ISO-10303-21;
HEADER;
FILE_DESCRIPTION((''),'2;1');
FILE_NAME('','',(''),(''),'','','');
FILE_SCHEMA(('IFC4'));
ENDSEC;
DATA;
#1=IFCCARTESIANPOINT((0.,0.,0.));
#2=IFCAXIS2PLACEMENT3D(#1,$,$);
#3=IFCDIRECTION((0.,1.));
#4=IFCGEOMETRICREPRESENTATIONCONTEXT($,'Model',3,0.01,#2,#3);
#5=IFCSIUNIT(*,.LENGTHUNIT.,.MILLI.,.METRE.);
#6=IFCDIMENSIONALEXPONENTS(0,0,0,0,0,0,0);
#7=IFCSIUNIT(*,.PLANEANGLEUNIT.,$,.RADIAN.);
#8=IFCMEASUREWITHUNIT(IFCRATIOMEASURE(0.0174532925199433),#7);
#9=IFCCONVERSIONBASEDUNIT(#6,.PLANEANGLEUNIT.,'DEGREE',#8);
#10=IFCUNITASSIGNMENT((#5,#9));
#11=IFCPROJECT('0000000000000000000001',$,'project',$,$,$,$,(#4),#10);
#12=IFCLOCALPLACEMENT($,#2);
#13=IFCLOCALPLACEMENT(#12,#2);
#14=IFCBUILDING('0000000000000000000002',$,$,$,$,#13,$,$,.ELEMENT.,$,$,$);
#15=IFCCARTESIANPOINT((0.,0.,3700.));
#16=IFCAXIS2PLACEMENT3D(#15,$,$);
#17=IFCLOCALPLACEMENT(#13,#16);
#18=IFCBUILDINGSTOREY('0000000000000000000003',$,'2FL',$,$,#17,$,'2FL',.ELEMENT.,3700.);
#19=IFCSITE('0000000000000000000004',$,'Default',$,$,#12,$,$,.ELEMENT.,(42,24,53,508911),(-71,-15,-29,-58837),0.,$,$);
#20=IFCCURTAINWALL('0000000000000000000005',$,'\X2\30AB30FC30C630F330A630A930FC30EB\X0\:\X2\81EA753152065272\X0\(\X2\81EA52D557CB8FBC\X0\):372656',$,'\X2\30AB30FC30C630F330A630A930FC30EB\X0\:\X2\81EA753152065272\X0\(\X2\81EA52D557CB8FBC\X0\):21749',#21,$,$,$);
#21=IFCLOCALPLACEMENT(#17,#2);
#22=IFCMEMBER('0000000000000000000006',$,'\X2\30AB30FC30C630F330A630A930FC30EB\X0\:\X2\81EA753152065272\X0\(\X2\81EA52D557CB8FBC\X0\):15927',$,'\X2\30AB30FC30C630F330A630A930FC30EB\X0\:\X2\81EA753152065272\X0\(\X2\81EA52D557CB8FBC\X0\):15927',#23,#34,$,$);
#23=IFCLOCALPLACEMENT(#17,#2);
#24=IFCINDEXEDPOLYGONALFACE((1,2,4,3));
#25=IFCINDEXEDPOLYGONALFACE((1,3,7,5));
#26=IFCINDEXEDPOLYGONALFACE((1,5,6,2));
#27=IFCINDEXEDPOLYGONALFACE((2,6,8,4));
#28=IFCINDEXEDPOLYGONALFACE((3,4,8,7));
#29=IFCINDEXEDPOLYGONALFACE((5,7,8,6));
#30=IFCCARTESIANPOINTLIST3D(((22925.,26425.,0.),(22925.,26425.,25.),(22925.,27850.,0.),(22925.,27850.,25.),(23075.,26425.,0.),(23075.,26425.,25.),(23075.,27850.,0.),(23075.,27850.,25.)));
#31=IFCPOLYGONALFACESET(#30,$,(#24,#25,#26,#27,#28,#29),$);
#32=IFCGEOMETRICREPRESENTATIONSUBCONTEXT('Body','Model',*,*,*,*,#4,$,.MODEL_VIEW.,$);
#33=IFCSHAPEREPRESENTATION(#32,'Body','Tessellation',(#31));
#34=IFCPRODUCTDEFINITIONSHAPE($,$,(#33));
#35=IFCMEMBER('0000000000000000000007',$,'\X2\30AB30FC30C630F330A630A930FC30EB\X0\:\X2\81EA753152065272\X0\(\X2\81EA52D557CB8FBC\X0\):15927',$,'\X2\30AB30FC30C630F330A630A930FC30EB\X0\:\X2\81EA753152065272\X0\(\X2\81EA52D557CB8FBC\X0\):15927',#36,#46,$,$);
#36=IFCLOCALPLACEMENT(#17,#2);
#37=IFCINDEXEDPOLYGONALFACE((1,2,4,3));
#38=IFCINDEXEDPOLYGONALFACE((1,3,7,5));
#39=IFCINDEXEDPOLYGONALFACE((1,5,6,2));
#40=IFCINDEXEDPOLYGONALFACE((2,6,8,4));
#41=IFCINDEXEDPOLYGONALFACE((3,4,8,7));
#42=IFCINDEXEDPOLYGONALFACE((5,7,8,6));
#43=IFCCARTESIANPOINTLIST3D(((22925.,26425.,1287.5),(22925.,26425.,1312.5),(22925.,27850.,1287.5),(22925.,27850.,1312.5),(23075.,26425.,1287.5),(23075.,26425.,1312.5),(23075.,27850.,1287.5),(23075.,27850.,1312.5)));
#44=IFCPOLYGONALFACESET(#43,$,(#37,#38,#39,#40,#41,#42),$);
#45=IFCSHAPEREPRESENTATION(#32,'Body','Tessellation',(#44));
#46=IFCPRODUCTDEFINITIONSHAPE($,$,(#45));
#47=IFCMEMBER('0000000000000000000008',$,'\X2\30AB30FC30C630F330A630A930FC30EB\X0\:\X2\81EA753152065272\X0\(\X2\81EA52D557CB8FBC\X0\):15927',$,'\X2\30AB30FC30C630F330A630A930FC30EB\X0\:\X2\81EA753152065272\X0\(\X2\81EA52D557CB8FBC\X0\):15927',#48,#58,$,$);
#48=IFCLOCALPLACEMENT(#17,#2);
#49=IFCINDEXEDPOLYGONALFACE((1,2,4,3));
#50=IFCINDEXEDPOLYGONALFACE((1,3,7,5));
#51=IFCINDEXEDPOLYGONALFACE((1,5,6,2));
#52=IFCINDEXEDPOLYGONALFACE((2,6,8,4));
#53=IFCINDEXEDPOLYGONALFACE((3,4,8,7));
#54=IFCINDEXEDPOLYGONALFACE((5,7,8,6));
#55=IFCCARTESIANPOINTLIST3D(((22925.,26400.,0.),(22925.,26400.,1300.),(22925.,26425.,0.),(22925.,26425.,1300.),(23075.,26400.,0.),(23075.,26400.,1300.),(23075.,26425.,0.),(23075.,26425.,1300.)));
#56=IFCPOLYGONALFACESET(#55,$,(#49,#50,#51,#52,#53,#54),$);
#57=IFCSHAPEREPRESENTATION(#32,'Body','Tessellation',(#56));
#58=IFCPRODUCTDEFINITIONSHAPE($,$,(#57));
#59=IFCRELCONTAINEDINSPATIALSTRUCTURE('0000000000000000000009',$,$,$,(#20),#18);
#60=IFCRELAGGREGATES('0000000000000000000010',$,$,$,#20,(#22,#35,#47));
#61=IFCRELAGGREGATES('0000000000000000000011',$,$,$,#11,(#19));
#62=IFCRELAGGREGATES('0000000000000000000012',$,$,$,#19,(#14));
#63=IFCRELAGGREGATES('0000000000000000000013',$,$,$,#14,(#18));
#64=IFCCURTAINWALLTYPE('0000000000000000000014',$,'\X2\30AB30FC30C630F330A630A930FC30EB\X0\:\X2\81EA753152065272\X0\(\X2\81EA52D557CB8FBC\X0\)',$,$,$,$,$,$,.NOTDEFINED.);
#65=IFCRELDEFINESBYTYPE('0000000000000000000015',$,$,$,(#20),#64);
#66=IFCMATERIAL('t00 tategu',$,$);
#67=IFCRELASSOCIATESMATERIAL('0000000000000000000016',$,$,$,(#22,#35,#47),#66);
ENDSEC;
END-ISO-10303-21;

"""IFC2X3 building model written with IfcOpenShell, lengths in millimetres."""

from ifc_helpers import new_model, entity, si_unit, converted_unit, direction, frame, frame_2d, origin, origin_2d_with_axis, place, context, subcontext, project, spatial, rectangle, extrude, material, type_object, element, aggregate, save


model = new_model("IFC2X3")

# Units and contexts
model_context = context("Model", 3, precision=0.01, world=origin(), true_north=direction((0.0, 1.0)))
body_context = subcontext(model_context, "Body", "Model", "MODEL_VIEW")
ifc_project = project(units=[si_unit("LENGTHUNIT", "METRE", prefix="MILLI"), converted_unit("PLANEANGLEUNIT", "DEGREE", entity("IfcRatioMeasure", 0.0174532925199433), si_unit("PLANEANGLEUNIT", "RADIAN"), dimensions=[0, 0, 0, 0, 0, 0, 0])], contexts=[model_context])

# Site, building, storey
site_placement = place(None, origin())
site = spatial("IfcSite", under=ifc_project, at=site_placement, Name="Default", CompositionType="ELEMENT", RefLatitude=(42, 24, 53, 508911), RefLongitude=(-71, -15, -29, -58837), RefElevation=0.0)
building_placement = place(site_placement, origin())
building = spatial("IfcBuilding", under=site, at=building_placement, CompositionType="ELEMENT")
storey_placement = place(building_placement, frame((0.0, 0.0, 3700.0)))
storey = spatial("IfcBuildingStorey", under=building, at=storey_placement, Name="2FL", LongName="2FL", CompositionType="ELEMENT", Elevation=3700.0)

# Curtain wall, members
curtain_wall_type = type_object("IfcCurtainWallType", Name="カーテンウォール:自由分割(自動埋込)", PredefinedType="NOTDEFINED")
ifc_material = material(Name="t00 tategu")
curtain_wall_1_placement = place(storey_placement, frame((0.0, 0.0, -3700.0)))
curtain_wall_1 = element("IfcCurtainWall", 1, at=curtain_wall_1_placement, inside=storey, type_object=curtain_wall_type, Name="カーテンウォール:自由分割(自動埋込):372656", ObjectType="カーテンウォール:自由分割(自動埋込):21749")
member_1_placement = place(curtain_wall_1_placement, frame((0.0, 0.0, 3700.0)))
member_1 = element("IfcMember", 2, at=member_1_placement, material=ifc_material, Name="カーテンウォール:自由分割(自動埋込):15927", ObjectType="カーテンウォール:自由分割(自動埋込):15927", context=body_context, shape_type="SweptSolid", body=[
    extrude(rectangle(XDim=25.0, YDim=150.0, at=origin_2d_with_axis()), frame((23000.0, 26425.0, 12.5), z_axis=(0.0, 1.0, 0.0), x_axis=(0.0, 0.0, -1.0)), (0.0, 0.0, 1.0), 1425.0),
])
member_2_placement = place(curtain_wall_1_placement, frame((0.0, 0.0, 3700.0)))
member_2 = element("IfcMember", 3, at=member_2_placement, material=ifc_material, Name="カーテンウォール:自由分割(自動埋込):15927", ObjectType="カーテンウォール:自由分割(自動埋込):15927", context=body_context, shape_type="SweptSolid", body=[
    extrude(rectangle(XDim=25.0, YDim=150.0, at=origin_2d_with_axis()), frame((23000.0, 27850.0, 1300.0), z_axis=(0.0, -1.0, 0.0), x_axis=(0.0, 0.0, -1.0)), (0.0, 0.0, 1.0), 1425.0),
])
member_3_placement = place(curtain_wall_1_placement, frame((0.0, 0.0, 3700.0)))
member_3 = element("IfcMember", 4, at=member_3_placement, material=ifc_material, Name="カーテンウォール:自由分割(自動埋込):15927", ObjectType="カーテンウォール:自由分割(自動埋込):15927", context=body_context, shape_type="SweptSolid", body=[
    extrude(rectangle(XDim=150.0, YDim=25.0, at=frame_2d((0.0, 0.0), x_axis=(1.0, 0.0))), frame((23000.0, 26412.5, 1300.0), z_axis=(0.0, 0.0, -1.0), x_axis=(-1.0, 0.0, 0.0)), (0.0, 0.0, 1.0), 1300.0),
])
aggregate(curtain_wall_1, [member_1, member_2, member_3])

save(model, "model.ifc")
